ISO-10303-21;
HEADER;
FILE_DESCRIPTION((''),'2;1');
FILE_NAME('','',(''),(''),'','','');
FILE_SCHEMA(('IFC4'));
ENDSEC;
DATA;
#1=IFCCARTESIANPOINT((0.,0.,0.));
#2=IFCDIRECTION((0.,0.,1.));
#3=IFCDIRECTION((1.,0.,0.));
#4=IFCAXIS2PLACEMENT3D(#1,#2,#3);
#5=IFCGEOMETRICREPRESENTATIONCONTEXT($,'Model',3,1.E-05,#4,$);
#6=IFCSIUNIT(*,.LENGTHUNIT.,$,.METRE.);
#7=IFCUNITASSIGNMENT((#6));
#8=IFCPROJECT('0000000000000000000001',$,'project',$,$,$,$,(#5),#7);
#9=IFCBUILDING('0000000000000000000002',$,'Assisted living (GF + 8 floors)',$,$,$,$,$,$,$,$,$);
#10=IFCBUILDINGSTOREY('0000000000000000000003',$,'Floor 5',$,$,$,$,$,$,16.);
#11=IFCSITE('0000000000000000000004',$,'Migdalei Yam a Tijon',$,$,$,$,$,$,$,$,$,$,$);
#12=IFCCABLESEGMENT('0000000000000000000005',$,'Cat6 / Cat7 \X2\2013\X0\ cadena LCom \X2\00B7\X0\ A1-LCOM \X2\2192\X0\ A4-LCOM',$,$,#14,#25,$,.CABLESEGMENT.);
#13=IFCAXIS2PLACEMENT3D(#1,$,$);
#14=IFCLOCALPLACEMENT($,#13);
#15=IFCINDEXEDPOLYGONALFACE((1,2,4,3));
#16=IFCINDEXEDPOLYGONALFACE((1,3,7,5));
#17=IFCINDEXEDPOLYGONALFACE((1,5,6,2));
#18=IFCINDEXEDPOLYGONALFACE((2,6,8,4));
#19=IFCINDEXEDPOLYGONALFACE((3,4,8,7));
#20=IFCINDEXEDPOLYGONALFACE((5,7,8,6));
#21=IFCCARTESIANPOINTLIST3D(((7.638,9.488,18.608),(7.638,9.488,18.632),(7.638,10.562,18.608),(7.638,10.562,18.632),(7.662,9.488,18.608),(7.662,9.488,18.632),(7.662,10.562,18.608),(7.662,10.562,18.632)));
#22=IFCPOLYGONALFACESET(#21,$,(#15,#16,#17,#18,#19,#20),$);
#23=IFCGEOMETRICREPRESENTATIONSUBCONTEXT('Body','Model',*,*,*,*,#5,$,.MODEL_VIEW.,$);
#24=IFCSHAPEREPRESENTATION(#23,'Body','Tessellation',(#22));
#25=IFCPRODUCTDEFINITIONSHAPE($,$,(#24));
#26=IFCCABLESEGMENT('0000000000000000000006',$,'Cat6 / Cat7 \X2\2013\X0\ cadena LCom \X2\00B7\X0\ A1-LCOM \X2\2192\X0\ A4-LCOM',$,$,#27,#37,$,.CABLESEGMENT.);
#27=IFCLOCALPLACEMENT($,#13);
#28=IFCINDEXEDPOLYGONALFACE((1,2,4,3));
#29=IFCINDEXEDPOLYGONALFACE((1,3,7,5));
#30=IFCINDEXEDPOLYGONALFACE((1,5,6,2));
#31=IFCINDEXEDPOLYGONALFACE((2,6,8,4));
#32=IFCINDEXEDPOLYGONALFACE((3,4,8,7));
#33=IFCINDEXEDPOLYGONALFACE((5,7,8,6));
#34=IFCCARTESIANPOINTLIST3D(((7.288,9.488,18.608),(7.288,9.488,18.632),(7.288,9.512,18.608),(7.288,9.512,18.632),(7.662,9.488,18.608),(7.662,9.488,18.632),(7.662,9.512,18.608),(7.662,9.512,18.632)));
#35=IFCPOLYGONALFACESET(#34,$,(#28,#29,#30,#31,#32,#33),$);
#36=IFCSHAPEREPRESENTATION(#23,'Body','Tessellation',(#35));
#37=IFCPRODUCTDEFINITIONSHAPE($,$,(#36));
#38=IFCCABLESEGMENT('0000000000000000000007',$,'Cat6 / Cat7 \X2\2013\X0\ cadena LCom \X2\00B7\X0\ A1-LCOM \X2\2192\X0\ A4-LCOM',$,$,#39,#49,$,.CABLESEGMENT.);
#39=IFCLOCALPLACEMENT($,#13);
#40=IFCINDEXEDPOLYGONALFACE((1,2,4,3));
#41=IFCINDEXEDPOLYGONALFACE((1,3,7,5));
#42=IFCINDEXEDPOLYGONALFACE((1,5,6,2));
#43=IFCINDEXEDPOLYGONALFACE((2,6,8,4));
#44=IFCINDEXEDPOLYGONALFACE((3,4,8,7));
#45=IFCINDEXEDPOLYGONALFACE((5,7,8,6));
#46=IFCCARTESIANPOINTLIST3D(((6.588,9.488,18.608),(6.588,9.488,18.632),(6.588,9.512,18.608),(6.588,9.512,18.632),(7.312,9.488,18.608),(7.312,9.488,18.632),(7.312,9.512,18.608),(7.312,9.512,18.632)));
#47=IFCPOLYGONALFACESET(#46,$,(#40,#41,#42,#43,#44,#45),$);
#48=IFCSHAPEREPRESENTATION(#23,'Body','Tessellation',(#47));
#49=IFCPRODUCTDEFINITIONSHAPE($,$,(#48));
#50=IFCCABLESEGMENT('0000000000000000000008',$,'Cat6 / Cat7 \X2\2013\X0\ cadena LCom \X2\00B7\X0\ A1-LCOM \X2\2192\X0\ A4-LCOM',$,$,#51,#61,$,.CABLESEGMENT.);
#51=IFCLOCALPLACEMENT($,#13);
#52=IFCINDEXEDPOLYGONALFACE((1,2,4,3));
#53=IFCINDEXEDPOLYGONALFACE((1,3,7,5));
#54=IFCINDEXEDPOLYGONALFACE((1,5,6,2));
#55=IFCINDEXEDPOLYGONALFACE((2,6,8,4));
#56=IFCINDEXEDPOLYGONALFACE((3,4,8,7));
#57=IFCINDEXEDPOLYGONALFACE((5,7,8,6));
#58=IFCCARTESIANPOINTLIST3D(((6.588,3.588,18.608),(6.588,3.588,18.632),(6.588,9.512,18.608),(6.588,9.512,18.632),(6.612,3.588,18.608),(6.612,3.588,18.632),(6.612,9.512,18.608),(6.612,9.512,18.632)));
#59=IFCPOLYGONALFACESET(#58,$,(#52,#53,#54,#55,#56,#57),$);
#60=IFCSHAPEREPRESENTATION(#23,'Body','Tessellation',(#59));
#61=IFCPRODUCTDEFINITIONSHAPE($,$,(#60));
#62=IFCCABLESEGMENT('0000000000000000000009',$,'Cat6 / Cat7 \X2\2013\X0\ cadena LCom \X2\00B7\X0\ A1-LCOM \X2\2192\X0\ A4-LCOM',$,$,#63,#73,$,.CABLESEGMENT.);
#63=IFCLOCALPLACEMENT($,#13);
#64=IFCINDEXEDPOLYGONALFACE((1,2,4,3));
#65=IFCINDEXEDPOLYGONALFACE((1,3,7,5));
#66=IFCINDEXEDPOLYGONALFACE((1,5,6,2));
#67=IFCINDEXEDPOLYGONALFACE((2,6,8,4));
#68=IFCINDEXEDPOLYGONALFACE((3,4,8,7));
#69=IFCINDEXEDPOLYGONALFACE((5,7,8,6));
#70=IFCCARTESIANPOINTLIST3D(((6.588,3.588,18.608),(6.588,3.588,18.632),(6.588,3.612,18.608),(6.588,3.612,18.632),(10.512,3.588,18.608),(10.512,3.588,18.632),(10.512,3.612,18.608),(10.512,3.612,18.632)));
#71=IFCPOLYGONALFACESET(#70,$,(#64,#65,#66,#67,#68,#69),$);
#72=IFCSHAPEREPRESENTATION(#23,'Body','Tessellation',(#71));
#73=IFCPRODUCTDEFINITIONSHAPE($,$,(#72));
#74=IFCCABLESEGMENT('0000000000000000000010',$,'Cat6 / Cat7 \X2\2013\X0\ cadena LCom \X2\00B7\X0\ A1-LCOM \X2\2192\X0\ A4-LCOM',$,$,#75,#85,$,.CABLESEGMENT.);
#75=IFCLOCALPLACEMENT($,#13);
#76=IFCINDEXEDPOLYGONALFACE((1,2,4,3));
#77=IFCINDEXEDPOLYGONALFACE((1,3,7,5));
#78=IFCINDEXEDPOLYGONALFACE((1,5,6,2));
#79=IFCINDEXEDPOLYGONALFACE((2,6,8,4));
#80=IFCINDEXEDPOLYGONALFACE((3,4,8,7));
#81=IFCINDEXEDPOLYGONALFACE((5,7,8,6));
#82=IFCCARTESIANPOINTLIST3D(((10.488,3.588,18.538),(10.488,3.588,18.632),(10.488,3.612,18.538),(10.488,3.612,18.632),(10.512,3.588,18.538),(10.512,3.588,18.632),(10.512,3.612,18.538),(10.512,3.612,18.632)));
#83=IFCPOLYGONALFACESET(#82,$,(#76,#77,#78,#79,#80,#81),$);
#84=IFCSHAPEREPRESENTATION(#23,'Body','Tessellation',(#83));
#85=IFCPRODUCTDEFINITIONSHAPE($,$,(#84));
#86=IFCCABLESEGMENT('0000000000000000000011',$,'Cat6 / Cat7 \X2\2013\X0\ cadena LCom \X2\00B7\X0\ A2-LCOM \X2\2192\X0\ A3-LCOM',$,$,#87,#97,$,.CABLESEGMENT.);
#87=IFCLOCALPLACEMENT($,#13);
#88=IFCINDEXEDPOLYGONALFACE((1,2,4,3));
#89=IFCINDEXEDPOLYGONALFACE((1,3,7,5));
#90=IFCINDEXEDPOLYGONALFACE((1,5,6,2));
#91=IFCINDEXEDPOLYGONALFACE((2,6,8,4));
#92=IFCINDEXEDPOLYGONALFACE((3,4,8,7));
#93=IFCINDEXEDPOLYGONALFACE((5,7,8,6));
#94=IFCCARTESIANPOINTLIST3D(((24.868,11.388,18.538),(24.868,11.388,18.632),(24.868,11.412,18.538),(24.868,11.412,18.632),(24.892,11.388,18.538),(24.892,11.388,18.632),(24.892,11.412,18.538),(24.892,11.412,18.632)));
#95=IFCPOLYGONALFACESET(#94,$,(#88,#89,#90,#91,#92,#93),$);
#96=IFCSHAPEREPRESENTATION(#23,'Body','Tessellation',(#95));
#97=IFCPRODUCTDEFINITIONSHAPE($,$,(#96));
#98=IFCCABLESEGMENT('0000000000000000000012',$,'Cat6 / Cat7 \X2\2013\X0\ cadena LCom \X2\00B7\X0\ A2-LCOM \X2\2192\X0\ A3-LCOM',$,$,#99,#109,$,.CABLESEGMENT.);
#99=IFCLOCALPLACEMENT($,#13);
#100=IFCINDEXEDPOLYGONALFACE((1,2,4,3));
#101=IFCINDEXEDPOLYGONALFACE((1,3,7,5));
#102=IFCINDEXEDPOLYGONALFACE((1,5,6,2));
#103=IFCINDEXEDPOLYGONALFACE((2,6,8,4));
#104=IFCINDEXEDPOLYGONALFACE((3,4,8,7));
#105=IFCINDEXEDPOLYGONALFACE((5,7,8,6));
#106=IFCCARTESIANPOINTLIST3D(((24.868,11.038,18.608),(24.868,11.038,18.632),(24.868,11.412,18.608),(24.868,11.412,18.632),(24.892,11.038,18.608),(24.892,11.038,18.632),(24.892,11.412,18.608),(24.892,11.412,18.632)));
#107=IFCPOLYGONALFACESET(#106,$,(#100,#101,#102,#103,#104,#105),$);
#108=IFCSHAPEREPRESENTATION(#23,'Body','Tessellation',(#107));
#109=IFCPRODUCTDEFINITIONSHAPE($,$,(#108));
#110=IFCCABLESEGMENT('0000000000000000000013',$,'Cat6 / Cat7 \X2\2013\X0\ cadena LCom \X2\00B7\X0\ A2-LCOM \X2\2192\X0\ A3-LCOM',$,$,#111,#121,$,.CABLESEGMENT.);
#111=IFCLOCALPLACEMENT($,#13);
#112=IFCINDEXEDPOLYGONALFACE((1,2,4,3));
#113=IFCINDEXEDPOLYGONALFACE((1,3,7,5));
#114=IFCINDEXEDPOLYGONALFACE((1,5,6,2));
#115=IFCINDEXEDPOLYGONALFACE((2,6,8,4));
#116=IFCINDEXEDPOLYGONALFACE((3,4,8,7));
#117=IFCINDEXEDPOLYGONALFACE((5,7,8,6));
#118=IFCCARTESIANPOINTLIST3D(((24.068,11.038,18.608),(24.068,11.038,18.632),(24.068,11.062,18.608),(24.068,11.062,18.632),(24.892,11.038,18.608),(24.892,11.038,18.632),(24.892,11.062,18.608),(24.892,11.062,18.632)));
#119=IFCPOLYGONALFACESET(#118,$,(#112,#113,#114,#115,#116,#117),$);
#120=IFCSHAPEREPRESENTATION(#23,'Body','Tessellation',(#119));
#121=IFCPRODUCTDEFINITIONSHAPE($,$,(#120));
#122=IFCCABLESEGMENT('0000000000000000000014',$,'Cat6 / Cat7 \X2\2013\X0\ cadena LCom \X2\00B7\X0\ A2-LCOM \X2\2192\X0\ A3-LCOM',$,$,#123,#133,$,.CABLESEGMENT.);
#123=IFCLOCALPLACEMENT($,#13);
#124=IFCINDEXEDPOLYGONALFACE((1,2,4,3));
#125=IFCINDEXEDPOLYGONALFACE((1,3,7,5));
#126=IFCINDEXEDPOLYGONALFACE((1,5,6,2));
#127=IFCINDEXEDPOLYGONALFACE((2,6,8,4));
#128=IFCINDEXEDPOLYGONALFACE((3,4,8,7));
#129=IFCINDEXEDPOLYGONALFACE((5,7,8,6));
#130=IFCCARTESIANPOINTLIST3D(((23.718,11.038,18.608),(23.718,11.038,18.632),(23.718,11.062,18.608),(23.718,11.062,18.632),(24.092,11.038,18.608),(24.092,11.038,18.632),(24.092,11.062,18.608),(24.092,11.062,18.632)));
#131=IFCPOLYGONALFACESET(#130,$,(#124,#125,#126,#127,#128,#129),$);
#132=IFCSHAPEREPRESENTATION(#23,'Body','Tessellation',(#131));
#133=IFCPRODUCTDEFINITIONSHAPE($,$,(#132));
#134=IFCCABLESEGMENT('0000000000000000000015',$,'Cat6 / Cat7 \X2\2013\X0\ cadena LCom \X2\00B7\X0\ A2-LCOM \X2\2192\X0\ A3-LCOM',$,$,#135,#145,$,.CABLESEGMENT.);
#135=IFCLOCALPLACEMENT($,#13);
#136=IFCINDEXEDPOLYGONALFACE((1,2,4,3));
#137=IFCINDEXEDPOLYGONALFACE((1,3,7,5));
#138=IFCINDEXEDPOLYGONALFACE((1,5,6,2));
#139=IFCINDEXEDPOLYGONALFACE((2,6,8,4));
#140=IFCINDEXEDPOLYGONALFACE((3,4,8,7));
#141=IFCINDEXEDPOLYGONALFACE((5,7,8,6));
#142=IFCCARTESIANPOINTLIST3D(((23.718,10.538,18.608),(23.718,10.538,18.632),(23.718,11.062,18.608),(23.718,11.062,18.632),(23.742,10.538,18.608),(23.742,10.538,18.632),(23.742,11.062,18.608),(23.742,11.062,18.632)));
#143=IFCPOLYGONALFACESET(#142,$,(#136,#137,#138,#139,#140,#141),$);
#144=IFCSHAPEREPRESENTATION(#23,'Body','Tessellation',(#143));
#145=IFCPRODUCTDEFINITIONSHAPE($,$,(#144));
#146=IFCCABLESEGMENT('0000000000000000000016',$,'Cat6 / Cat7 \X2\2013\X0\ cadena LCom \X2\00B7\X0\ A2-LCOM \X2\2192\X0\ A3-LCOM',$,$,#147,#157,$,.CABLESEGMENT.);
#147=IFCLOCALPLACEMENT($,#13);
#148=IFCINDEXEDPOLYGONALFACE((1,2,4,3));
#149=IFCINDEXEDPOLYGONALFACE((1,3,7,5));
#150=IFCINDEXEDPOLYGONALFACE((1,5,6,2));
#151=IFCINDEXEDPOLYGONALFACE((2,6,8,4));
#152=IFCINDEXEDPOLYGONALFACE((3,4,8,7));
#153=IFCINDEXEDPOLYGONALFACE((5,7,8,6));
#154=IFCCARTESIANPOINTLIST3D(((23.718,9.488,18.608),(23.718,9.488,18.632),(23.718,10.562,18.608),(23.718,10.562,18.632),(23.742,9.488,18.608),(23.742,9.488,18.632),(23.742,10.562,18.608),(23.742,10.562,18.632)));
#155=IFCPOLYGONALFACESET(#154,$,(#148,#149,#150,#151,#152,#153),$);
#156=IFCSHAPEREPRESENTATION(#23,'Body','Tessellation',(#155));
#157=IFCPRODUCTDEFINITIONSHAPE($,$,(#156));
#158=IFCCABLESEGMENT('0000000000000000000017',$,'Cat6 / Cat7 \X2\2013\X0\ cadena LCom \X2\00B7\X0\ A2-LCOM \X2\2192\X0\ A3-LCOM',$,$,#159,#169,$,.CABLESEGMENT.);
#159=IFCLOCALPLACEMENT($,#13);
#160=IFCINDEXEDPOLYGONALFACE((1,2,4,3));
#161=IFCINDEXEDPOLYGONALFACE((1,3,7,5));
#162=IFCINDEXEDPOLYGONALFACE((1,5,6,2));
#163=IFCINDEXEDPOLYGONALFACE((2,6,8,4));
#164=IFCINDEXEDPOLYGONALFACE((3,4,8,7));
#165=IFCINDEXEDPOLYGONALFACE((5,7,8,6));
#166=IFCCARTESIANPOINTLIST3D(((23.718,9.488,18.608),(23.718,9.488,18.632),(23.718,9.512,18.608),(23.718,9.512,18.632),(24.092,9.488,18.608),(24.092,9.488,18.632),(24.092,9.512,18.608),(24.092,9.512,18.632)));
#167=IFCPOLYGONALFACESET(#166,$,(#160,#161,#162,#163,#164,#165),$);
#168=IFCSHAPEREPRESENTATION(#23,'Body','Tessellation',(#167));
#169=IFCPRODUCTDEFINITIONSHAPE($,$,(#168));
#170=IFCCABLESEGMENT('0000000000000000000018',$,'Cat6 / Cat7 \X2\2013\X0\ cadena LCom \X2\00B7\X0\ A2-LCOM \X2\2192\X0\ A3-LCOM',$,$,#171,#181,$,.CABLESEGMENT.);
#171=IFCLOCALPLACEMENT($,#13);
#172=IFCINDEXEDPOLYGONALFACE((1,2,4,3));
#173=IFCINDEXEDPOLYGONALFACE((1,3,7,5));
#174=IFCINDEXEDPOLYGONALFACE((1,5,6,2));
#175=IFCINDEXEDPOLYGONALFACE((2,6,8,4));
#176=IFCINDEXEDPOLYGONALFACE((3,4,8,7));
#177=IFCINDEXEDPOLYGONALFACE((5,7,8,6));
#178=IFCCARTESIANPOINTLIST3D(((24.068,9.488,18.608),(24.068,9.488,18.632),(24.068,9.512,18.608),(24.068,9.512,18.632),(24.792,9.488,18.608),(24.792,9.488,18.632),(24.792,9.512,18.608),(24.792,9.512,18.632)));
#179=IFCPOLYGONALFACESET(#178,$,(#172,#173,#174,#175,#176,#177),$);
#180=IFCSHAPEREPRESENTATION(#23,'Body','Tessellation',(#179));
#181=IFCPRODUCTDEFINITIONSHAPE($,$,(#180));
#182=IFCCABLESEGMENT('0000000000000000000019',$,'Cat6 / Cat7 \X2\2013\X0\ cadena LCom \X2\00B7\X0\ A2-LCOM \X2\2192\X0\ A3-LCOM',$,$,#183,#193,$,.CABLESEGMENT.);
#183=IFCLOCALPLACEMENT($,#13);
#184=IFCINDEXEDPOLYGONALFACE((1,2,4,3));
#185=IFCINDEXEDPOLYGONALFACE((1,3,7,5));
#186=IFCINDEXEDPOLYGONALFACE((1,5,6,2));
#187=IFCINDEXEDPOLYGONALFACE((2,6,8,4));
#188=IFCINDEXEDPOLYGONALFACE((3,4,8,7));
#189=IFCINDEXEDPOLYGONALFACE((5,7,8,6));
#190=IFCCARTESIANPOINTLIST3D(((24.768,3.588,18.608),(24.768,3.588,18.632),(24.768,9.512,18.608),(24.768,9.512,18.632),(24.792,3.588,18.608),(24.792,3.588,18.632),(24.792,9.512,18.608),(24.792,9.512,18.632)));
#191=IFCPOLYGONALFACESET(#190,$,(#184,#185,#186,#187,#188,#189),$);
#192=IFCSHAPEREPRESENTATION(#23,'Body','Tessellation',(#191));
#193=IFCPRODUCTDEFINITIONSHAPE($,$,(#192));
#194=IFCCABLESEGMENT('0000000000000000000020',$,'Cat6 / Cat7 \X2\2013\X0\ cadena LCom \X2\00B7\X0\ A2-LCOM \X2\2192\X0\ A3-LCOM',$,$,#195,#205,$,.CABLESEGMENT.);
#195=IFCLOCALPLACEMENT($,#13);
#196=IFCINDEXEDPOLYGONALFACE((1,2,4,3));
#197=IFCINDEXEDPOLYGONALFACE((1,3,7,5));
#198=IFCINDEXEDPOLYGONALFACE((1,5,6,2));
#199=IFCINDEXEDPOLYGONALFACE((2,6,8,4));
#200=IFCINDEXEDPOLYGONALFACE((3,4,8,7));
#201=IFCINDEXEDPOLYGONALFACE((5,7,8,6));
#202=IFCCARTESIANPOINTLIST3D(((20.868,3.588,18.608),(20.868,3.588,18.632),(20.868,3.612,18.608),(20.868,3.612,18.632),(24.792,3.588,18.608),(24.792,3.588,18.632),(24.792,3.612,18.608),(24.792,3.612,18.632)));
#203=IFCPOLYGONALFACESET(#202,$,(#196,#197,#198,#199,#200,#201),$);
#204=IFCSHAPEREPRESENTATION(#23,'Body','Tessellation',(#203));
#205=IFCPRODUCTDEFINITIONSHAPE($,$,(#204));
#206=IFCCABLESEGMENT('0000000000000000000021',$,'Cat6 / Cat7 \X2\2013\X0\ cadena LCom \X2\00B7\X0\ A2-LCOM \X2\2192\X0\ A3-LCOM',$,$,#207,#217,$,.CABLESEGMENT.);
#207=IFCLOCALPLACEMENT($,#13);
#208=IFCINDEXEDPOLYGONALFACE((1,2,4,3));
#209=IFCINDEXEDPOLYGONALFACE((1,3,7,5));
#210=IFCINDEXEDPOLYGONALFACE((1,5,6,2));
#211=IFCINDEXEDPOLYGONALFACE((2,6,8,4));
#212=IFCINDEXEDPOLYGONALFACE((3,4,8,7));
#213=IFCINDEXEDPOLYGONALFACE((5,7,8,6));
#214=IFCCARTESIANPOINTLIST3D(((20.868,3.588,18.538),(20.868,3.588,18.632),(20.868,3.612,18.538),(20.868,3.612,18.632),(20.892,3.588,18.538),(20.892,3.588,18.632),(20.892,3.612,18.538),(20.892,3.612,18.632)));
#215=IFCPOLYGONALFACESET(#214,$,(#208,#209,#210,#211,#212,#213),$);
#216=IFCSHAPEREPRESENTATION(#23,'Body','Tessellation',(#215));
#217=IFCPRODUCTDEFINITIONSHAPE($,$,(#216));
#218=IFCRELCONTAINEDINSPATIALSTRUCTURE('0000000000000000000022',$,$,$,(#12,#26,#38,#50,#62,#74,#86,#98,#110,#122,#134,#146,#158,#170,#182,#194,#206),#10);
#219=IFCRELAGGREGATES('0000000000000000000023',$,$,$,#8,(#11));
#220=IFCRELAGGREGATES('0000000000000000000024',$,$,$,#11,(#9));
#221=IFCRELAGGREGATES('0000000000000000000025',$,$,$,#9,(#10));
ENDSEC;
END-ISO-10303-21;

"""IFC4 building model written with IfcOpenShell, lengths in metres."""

from ifc_helpers import new_model, si_unit, frame, origin_with_axes, context, subcontext, project, spatial, line, indexed_curve, outline, extrude, element, save


model = new_model("IFC4")

# Units and contexts
model_context = context("Model", 3, precision=1e-05, world=origin_with_axes())
body_context = subcontext(model_context, "Body", "Model", "MODEL_VIEW")
ifc_project = project(units=[si_unit("LENGTHUNIT", "METRE")], contexts=[model_context])

# Site, building, storey
site = spatial("IfcSite", under=ifc_project, Name="Migdalei Yam a Tijon")
building = spatial("IfcBuilding", under=site, Name="Assisted living (GF + 8 floors)")
storey = spatial("IfcBuildingStorey", under=building, Name="Floor 5", Elevation=16.0)

# Cable segments
element("IfcCableSegment", 1, inside=storey, Name="Cat6 / Cat7 – cadena LCom · A1-LCOM → A4-LCOM", PredefinedType="CABLESEGMENT", context=body_context, shape_type="SweptSolid", body=[
    extrude(outline(indexed_curve([(0.0, 0.0), (0.024, 0.0), (0.024, 1.074), (0.0, 1.074)], segments=[line(1, 2, 3, 4, 1)])), frame((7.638, 9.488, 18.608), z_axis=(0.0, 0.0, 1.0), x_axis=(1.0, 0.0, 0.0)), (0.0, 0.0, 1.0), 0.024),
])
element("IfcCableSegment", 2, inside=storey, Name="Cat6 / Cat7 – cadena LCom · A1-LCOM → A4-LCOM", PredefinedType="CABLESEGMENT", context=body_context, shape_type="SweptSolid", body=[
    extrude(outline(indexed_curve([(0.0, 0.0), (0.374, 0.0), (0.374, 0.024), (0.0, 0.024)], segments=[line(1, 2, 3, 4, 1)])), frame((7.288, 9.488, 18.608), z_axis=(0.0, 0.0, 1.0), x_axis=(1.0, 0.0, 0.0)), (0.0, 0.0, 1.0), 0.024),
])
element("IfcCableSegment", 3, inside=storey, Name="Cat6 / Cat7 – cadena LCom · A1-LCOM → A4-LCOM", PredefinedType="CABLESEGMENT", context=body_context, shape_type="SweptSolid", body=[
    extrude(outline(indexed_curve([(0.0, 0.0), (0.724, 0.0), (0.724, 0.024), (0.0, 0.024)], segments=[line(1, 2, 3, 4, 1)])), frame((6.588, 9.488, 18.608), z_axis=(0.0, 0.0, 1.0), x_axis=(1.0, 0.0, 0.0)), (0.0, 0.0, 1.0), 0.024),
])
element("IfcCableSegment", 4, inside=storey, Name="Cat6 / Cat7 – cadena LCom · A1-LCOM → A4-LCOM", PredefinedType="CABLESEGMENT", context=body_context, shape_type="SweptSolid", body=[
    extrude(outline(indexed_curve([(0.0, 0.0), (0.024, 0.0), (0.024, 5.924), (0.0, 5.924)], segments=[line(1, 2, 3, 4, 1)])), frame((6.588, 3.588, 18.608), z_axis=(0.0, 0.0, 1.0), x_axis=(1.0, 0.0, 0.0)), (0.0, 0.0, 1.0), 0.024),
])
element("IfcCableSegment", 5, inside=storey, Name="Cat6 / Cat7 – cadena LCom · A1-LCOM → A4-LCOM", PredefinedType="CABLESEGMENT", context=body_context, shape_type="SweptSolid", body=[
    extrude(outline(indexed_curve([(0.0, 0.0), (3.924, 0.0), (3.924, 0.024), (0.0, 0.024)], segments=[line(1, 2, 3, 4, 1)])), frame((6.588, 3.588, 18.608), z_axis=(0.0, 0.0, 1.0), x_axis=(1.0, 0.0, 0.0)), (0.0, 0.0, 1.0), 0.024),
])
element("IfcCableSegment", 6, inside=storey, Name="Cat6 / Cat7 – cadena LCom · A1-LCOM → A4-LCOM", PredefinedType="CABLESEGMENT", context=body_context, shape_type="SweptSolid", body=[
    extrude(outline(indexed_curve([(0.0, 0.0), (0.024, 0.0), (0.024, 0.024), (0.0, 0.024)], segments=[line(1, 2, 3, 4, 1)])), frame((10.488, 3.588, 18.538), z_axis=(0.0, 0.0, 1.0), x_axis=(1.0, 0.0, 0.0)), (0.0, 0.0, 1.0), 0.094),
])
element("IfcCableSegment", 7, inside=storey, Name="Cat6 / Cat7 – cadena LCom · A2-LCOM → A3-LCOM", PredefinedType="CABLESEGMENT", context=body_context, shape_type="SweptSolid", body=[
    extrude(outline(indexed_curve([(0.0, 0.0), (0.024, 0.0), (0.024, 0.024), (0.0, 0.024)], segments=[line(1, 2, 3, 4, 1)])), frame((24.868, 11.388, 18.538), z_axis=(0.0, 0.0, 1.0), x_axis=(1.0, 0.0, 0.0)), (0.0, 0.0, 1.0), 0.094),
])
element("IfcCableSegment", 8, inside=storey, Name="Cat6 / Cat7 – cadena LCom · A2-LCOM → A3-LCOM", PredefinedType="CABLESEGMENT", context=body_context, shape_type="SweptSolid", body=[
    extrude(outline(indexed_curve([(0.0, 0.0), (0.024, 0.0), (0.024, 0.374), (0.0, 0.374)], segments=[line(1, 2, 3, 4, 1)])), frame((24.868, 11.038, 18.608), z_axis=(0.0, 0.0, 1.0), x_axis=(1.0, 0.0, 0.0)), (0.0, 0.0, 1.0), 0.024),
])
element("IfcCableSegment", 9, inside=storey, Name="Cat6 / Cat7 – cadena LCom · A2-LCOM → A3-LCOM", PredefinedType="CABLESEGMENT", context=body_context, shape_type="SweptSolid", body=[
    extrude(outline(indexed_curve([(0.0, 0.0), (0.824, 0.0), (0.824, 0.024), (0.0, 0.024)], segments=[line(1, 2, 3, 4, 1)])), frame((24.068, 11.038, 18.608), z_axis=(0.0, 0.0, 1.0), x_axis=(1.0, 0.0, 0.0)), (0.0, 0.0, 1.0), 0.024),
])
element("IfcCableSegment", 10, inside=storey, Name="Cat6 / Cat7 – cadena LCom · A2-LCOM → A3-LCOM", PredefinedType="CABLESEGMENT", context=body_context, shape_type="SweptSolid", body=[
    extrude(outline(indexed_curve([(0.0, 0.0), (0.374, 0.0), (0.374, 0.024), (0.0, 0.024)], segments=[line(1, 2, 3, 4, 1)])), frame((23.718, 11.038, 18.608), z_axis=(0.0, 0.0, 1.0), x_axis=(1.0, 0.0, 0.0)), (0.0, 0.0, 1.0), 0.024),
])
element("IfcCableSegment", 11, inside=storey, Name="Cat6 / Cat7 – cadena LCom · A2-LCOM → A3-LCOM", PredefinedType="CABLESEGMENT", context=body_context, shape_type="SweptSolid", body=[
    extrude(outline(indexed_curve([(0.0, 0.0), (0.024, 0.0), (0.024, 0.524), (0.0, 0.524)], segments=[line(1, 2, 3, 4, 1)])), frame((23.718, 10.538, 18.608), z_axis=(0.0, 0.0, 1.0), x_axis=(1.0, 0.0, 0.0)), (0.0, 0.0, 1.0), 0.024),
])
element("IfcCableSegment", 12, inside=storey, Name="Cat6 / Cat7 – cadena LCom · A2-LCOM → A3-LCOM", PredefinedType="CABLESEGMENT", context=body_context, shape_type="SweptSolid", body=[
    extrude(outline(indexed_curve([(0.0, 0.0), (0.024, 0.0), (0.024, 1.074), (0.0, 1.074)], segments=[line(1, 2, 3, 4, 1)])), frame((23.718, 9.488, 18.608), z_axis=(0.0, 0.0, 1.0), x_axis=(1.0, 0.0, 0.0)), (0.0, 0.0, 1.0), 0.024),
])
element("IfcCableSegment", 13, inside=storey, Name="Cat6 / Cat7 – cadena LCom · A2-LCOM → A3-LCOM", PredefinedType="CABLESEGMENT", context=body_context, shape_type="SweptSolid", body=[
    extrude(outline(indexed_curve([(0.0, 0.0), (0.374, 0.0), (0.374, 0.024), (0.0, 0.024)], segments=[line(1, 2, 3, 4, 1)])), frame((23.718, 9.488, 18.608), z_axis=(0.0, 0.0, 1.0), x_axis=(1.0, 0.0, 0.0)), (0.0, 0.0, 1.0), 0.024),
])
element("IfcCableSegment", 14, inside=storey, Name="Cat6 / Cat7 – cadena LCom · A2-LCOM → A3-LCOM", PredefinedType="CABLESEGMENT", context=body_context, shape_type="SweptSolid", body=[
    extrude(outline(indexed_curve([(0.0, 0.0), (0.724, 0.0), (0.724, 0.024), (0.0, 0.024)], segments=[line(1, 2, 3, 4, 1)])), frame((24.068, 9.488, 18.608), z_axis=(0.0, 0.0, 1.0), x_axis=(1.0, 0.0, 0.0)), (0.0, 0.0, 1.0), 0.024),
])
element("IfcCableSegment", 15, inside=storey, Name="Cat6 / Cat7 – cadena LCom · A2-LCOM → A3-LCOM", PredefinedType="CABLESEGMENT", context=body_context, shape_type="SweptSolid", body=[
    extrude(outline(indexed_curve([(0.0, 0.0), (0.024, 0.0), (0.024, 5.924), (0.0, 5.924)], segments=[line(1, 2, 3, 4, 1)])), frame((24.768, 3.588, 18.608), z_axis=(0.0, 0.0, 1.0), x_axis=(1.0, 0.0, 0.0)), (0.0, 0.0, 1.0), 0.024),
])
element("IfcCableSegment", 16, inside=storey, Name="Cat6 / Cat7 – cadena LCom · A2-LCOM → A3-LCOM", PredefinedType="CABLESEGMENT", context=body_context, shape_type="SweptSolid", body=[
    extrude(outline(indexed_curve([(0.0, 0.0), (3.924, 0.0), (3.924, 0.024), (0.0, 0.024)], segments=[line(1, 2, 3, 4, 1)])), frame((20.868, 3.588, 18.608), z_axis=(0.0, 0.0, 1.0), x_axis=(1.0, 0.0, 0.0)), (0.0, 0.0, 1.0), 0.024),
])
element("IfcCableSegment", 17, inside=storey, Name="Cat6 / Cat7 – cadena LCom · A2-LCOM → A3-LCOM", PredefinedType="CABLESEGMENT", context=body_context, shape_type="SweptSolid", body=[
    extrude(outline(indexed_curve([(0.0, 0.0), (0.024, 0.0), (0.024, 0.024), (0.0, 0.024)], segments=[line(1, 2, 3, 4, 1)])), frame((20.868, 3.588, 18.538), z_axis=(0.0, 0.0, 1.0), x_axis=(1.0, 0.0, 0.0)), (0.0, 0.0, 1.0), 0.094),
])

save(model, "model.ifc")
